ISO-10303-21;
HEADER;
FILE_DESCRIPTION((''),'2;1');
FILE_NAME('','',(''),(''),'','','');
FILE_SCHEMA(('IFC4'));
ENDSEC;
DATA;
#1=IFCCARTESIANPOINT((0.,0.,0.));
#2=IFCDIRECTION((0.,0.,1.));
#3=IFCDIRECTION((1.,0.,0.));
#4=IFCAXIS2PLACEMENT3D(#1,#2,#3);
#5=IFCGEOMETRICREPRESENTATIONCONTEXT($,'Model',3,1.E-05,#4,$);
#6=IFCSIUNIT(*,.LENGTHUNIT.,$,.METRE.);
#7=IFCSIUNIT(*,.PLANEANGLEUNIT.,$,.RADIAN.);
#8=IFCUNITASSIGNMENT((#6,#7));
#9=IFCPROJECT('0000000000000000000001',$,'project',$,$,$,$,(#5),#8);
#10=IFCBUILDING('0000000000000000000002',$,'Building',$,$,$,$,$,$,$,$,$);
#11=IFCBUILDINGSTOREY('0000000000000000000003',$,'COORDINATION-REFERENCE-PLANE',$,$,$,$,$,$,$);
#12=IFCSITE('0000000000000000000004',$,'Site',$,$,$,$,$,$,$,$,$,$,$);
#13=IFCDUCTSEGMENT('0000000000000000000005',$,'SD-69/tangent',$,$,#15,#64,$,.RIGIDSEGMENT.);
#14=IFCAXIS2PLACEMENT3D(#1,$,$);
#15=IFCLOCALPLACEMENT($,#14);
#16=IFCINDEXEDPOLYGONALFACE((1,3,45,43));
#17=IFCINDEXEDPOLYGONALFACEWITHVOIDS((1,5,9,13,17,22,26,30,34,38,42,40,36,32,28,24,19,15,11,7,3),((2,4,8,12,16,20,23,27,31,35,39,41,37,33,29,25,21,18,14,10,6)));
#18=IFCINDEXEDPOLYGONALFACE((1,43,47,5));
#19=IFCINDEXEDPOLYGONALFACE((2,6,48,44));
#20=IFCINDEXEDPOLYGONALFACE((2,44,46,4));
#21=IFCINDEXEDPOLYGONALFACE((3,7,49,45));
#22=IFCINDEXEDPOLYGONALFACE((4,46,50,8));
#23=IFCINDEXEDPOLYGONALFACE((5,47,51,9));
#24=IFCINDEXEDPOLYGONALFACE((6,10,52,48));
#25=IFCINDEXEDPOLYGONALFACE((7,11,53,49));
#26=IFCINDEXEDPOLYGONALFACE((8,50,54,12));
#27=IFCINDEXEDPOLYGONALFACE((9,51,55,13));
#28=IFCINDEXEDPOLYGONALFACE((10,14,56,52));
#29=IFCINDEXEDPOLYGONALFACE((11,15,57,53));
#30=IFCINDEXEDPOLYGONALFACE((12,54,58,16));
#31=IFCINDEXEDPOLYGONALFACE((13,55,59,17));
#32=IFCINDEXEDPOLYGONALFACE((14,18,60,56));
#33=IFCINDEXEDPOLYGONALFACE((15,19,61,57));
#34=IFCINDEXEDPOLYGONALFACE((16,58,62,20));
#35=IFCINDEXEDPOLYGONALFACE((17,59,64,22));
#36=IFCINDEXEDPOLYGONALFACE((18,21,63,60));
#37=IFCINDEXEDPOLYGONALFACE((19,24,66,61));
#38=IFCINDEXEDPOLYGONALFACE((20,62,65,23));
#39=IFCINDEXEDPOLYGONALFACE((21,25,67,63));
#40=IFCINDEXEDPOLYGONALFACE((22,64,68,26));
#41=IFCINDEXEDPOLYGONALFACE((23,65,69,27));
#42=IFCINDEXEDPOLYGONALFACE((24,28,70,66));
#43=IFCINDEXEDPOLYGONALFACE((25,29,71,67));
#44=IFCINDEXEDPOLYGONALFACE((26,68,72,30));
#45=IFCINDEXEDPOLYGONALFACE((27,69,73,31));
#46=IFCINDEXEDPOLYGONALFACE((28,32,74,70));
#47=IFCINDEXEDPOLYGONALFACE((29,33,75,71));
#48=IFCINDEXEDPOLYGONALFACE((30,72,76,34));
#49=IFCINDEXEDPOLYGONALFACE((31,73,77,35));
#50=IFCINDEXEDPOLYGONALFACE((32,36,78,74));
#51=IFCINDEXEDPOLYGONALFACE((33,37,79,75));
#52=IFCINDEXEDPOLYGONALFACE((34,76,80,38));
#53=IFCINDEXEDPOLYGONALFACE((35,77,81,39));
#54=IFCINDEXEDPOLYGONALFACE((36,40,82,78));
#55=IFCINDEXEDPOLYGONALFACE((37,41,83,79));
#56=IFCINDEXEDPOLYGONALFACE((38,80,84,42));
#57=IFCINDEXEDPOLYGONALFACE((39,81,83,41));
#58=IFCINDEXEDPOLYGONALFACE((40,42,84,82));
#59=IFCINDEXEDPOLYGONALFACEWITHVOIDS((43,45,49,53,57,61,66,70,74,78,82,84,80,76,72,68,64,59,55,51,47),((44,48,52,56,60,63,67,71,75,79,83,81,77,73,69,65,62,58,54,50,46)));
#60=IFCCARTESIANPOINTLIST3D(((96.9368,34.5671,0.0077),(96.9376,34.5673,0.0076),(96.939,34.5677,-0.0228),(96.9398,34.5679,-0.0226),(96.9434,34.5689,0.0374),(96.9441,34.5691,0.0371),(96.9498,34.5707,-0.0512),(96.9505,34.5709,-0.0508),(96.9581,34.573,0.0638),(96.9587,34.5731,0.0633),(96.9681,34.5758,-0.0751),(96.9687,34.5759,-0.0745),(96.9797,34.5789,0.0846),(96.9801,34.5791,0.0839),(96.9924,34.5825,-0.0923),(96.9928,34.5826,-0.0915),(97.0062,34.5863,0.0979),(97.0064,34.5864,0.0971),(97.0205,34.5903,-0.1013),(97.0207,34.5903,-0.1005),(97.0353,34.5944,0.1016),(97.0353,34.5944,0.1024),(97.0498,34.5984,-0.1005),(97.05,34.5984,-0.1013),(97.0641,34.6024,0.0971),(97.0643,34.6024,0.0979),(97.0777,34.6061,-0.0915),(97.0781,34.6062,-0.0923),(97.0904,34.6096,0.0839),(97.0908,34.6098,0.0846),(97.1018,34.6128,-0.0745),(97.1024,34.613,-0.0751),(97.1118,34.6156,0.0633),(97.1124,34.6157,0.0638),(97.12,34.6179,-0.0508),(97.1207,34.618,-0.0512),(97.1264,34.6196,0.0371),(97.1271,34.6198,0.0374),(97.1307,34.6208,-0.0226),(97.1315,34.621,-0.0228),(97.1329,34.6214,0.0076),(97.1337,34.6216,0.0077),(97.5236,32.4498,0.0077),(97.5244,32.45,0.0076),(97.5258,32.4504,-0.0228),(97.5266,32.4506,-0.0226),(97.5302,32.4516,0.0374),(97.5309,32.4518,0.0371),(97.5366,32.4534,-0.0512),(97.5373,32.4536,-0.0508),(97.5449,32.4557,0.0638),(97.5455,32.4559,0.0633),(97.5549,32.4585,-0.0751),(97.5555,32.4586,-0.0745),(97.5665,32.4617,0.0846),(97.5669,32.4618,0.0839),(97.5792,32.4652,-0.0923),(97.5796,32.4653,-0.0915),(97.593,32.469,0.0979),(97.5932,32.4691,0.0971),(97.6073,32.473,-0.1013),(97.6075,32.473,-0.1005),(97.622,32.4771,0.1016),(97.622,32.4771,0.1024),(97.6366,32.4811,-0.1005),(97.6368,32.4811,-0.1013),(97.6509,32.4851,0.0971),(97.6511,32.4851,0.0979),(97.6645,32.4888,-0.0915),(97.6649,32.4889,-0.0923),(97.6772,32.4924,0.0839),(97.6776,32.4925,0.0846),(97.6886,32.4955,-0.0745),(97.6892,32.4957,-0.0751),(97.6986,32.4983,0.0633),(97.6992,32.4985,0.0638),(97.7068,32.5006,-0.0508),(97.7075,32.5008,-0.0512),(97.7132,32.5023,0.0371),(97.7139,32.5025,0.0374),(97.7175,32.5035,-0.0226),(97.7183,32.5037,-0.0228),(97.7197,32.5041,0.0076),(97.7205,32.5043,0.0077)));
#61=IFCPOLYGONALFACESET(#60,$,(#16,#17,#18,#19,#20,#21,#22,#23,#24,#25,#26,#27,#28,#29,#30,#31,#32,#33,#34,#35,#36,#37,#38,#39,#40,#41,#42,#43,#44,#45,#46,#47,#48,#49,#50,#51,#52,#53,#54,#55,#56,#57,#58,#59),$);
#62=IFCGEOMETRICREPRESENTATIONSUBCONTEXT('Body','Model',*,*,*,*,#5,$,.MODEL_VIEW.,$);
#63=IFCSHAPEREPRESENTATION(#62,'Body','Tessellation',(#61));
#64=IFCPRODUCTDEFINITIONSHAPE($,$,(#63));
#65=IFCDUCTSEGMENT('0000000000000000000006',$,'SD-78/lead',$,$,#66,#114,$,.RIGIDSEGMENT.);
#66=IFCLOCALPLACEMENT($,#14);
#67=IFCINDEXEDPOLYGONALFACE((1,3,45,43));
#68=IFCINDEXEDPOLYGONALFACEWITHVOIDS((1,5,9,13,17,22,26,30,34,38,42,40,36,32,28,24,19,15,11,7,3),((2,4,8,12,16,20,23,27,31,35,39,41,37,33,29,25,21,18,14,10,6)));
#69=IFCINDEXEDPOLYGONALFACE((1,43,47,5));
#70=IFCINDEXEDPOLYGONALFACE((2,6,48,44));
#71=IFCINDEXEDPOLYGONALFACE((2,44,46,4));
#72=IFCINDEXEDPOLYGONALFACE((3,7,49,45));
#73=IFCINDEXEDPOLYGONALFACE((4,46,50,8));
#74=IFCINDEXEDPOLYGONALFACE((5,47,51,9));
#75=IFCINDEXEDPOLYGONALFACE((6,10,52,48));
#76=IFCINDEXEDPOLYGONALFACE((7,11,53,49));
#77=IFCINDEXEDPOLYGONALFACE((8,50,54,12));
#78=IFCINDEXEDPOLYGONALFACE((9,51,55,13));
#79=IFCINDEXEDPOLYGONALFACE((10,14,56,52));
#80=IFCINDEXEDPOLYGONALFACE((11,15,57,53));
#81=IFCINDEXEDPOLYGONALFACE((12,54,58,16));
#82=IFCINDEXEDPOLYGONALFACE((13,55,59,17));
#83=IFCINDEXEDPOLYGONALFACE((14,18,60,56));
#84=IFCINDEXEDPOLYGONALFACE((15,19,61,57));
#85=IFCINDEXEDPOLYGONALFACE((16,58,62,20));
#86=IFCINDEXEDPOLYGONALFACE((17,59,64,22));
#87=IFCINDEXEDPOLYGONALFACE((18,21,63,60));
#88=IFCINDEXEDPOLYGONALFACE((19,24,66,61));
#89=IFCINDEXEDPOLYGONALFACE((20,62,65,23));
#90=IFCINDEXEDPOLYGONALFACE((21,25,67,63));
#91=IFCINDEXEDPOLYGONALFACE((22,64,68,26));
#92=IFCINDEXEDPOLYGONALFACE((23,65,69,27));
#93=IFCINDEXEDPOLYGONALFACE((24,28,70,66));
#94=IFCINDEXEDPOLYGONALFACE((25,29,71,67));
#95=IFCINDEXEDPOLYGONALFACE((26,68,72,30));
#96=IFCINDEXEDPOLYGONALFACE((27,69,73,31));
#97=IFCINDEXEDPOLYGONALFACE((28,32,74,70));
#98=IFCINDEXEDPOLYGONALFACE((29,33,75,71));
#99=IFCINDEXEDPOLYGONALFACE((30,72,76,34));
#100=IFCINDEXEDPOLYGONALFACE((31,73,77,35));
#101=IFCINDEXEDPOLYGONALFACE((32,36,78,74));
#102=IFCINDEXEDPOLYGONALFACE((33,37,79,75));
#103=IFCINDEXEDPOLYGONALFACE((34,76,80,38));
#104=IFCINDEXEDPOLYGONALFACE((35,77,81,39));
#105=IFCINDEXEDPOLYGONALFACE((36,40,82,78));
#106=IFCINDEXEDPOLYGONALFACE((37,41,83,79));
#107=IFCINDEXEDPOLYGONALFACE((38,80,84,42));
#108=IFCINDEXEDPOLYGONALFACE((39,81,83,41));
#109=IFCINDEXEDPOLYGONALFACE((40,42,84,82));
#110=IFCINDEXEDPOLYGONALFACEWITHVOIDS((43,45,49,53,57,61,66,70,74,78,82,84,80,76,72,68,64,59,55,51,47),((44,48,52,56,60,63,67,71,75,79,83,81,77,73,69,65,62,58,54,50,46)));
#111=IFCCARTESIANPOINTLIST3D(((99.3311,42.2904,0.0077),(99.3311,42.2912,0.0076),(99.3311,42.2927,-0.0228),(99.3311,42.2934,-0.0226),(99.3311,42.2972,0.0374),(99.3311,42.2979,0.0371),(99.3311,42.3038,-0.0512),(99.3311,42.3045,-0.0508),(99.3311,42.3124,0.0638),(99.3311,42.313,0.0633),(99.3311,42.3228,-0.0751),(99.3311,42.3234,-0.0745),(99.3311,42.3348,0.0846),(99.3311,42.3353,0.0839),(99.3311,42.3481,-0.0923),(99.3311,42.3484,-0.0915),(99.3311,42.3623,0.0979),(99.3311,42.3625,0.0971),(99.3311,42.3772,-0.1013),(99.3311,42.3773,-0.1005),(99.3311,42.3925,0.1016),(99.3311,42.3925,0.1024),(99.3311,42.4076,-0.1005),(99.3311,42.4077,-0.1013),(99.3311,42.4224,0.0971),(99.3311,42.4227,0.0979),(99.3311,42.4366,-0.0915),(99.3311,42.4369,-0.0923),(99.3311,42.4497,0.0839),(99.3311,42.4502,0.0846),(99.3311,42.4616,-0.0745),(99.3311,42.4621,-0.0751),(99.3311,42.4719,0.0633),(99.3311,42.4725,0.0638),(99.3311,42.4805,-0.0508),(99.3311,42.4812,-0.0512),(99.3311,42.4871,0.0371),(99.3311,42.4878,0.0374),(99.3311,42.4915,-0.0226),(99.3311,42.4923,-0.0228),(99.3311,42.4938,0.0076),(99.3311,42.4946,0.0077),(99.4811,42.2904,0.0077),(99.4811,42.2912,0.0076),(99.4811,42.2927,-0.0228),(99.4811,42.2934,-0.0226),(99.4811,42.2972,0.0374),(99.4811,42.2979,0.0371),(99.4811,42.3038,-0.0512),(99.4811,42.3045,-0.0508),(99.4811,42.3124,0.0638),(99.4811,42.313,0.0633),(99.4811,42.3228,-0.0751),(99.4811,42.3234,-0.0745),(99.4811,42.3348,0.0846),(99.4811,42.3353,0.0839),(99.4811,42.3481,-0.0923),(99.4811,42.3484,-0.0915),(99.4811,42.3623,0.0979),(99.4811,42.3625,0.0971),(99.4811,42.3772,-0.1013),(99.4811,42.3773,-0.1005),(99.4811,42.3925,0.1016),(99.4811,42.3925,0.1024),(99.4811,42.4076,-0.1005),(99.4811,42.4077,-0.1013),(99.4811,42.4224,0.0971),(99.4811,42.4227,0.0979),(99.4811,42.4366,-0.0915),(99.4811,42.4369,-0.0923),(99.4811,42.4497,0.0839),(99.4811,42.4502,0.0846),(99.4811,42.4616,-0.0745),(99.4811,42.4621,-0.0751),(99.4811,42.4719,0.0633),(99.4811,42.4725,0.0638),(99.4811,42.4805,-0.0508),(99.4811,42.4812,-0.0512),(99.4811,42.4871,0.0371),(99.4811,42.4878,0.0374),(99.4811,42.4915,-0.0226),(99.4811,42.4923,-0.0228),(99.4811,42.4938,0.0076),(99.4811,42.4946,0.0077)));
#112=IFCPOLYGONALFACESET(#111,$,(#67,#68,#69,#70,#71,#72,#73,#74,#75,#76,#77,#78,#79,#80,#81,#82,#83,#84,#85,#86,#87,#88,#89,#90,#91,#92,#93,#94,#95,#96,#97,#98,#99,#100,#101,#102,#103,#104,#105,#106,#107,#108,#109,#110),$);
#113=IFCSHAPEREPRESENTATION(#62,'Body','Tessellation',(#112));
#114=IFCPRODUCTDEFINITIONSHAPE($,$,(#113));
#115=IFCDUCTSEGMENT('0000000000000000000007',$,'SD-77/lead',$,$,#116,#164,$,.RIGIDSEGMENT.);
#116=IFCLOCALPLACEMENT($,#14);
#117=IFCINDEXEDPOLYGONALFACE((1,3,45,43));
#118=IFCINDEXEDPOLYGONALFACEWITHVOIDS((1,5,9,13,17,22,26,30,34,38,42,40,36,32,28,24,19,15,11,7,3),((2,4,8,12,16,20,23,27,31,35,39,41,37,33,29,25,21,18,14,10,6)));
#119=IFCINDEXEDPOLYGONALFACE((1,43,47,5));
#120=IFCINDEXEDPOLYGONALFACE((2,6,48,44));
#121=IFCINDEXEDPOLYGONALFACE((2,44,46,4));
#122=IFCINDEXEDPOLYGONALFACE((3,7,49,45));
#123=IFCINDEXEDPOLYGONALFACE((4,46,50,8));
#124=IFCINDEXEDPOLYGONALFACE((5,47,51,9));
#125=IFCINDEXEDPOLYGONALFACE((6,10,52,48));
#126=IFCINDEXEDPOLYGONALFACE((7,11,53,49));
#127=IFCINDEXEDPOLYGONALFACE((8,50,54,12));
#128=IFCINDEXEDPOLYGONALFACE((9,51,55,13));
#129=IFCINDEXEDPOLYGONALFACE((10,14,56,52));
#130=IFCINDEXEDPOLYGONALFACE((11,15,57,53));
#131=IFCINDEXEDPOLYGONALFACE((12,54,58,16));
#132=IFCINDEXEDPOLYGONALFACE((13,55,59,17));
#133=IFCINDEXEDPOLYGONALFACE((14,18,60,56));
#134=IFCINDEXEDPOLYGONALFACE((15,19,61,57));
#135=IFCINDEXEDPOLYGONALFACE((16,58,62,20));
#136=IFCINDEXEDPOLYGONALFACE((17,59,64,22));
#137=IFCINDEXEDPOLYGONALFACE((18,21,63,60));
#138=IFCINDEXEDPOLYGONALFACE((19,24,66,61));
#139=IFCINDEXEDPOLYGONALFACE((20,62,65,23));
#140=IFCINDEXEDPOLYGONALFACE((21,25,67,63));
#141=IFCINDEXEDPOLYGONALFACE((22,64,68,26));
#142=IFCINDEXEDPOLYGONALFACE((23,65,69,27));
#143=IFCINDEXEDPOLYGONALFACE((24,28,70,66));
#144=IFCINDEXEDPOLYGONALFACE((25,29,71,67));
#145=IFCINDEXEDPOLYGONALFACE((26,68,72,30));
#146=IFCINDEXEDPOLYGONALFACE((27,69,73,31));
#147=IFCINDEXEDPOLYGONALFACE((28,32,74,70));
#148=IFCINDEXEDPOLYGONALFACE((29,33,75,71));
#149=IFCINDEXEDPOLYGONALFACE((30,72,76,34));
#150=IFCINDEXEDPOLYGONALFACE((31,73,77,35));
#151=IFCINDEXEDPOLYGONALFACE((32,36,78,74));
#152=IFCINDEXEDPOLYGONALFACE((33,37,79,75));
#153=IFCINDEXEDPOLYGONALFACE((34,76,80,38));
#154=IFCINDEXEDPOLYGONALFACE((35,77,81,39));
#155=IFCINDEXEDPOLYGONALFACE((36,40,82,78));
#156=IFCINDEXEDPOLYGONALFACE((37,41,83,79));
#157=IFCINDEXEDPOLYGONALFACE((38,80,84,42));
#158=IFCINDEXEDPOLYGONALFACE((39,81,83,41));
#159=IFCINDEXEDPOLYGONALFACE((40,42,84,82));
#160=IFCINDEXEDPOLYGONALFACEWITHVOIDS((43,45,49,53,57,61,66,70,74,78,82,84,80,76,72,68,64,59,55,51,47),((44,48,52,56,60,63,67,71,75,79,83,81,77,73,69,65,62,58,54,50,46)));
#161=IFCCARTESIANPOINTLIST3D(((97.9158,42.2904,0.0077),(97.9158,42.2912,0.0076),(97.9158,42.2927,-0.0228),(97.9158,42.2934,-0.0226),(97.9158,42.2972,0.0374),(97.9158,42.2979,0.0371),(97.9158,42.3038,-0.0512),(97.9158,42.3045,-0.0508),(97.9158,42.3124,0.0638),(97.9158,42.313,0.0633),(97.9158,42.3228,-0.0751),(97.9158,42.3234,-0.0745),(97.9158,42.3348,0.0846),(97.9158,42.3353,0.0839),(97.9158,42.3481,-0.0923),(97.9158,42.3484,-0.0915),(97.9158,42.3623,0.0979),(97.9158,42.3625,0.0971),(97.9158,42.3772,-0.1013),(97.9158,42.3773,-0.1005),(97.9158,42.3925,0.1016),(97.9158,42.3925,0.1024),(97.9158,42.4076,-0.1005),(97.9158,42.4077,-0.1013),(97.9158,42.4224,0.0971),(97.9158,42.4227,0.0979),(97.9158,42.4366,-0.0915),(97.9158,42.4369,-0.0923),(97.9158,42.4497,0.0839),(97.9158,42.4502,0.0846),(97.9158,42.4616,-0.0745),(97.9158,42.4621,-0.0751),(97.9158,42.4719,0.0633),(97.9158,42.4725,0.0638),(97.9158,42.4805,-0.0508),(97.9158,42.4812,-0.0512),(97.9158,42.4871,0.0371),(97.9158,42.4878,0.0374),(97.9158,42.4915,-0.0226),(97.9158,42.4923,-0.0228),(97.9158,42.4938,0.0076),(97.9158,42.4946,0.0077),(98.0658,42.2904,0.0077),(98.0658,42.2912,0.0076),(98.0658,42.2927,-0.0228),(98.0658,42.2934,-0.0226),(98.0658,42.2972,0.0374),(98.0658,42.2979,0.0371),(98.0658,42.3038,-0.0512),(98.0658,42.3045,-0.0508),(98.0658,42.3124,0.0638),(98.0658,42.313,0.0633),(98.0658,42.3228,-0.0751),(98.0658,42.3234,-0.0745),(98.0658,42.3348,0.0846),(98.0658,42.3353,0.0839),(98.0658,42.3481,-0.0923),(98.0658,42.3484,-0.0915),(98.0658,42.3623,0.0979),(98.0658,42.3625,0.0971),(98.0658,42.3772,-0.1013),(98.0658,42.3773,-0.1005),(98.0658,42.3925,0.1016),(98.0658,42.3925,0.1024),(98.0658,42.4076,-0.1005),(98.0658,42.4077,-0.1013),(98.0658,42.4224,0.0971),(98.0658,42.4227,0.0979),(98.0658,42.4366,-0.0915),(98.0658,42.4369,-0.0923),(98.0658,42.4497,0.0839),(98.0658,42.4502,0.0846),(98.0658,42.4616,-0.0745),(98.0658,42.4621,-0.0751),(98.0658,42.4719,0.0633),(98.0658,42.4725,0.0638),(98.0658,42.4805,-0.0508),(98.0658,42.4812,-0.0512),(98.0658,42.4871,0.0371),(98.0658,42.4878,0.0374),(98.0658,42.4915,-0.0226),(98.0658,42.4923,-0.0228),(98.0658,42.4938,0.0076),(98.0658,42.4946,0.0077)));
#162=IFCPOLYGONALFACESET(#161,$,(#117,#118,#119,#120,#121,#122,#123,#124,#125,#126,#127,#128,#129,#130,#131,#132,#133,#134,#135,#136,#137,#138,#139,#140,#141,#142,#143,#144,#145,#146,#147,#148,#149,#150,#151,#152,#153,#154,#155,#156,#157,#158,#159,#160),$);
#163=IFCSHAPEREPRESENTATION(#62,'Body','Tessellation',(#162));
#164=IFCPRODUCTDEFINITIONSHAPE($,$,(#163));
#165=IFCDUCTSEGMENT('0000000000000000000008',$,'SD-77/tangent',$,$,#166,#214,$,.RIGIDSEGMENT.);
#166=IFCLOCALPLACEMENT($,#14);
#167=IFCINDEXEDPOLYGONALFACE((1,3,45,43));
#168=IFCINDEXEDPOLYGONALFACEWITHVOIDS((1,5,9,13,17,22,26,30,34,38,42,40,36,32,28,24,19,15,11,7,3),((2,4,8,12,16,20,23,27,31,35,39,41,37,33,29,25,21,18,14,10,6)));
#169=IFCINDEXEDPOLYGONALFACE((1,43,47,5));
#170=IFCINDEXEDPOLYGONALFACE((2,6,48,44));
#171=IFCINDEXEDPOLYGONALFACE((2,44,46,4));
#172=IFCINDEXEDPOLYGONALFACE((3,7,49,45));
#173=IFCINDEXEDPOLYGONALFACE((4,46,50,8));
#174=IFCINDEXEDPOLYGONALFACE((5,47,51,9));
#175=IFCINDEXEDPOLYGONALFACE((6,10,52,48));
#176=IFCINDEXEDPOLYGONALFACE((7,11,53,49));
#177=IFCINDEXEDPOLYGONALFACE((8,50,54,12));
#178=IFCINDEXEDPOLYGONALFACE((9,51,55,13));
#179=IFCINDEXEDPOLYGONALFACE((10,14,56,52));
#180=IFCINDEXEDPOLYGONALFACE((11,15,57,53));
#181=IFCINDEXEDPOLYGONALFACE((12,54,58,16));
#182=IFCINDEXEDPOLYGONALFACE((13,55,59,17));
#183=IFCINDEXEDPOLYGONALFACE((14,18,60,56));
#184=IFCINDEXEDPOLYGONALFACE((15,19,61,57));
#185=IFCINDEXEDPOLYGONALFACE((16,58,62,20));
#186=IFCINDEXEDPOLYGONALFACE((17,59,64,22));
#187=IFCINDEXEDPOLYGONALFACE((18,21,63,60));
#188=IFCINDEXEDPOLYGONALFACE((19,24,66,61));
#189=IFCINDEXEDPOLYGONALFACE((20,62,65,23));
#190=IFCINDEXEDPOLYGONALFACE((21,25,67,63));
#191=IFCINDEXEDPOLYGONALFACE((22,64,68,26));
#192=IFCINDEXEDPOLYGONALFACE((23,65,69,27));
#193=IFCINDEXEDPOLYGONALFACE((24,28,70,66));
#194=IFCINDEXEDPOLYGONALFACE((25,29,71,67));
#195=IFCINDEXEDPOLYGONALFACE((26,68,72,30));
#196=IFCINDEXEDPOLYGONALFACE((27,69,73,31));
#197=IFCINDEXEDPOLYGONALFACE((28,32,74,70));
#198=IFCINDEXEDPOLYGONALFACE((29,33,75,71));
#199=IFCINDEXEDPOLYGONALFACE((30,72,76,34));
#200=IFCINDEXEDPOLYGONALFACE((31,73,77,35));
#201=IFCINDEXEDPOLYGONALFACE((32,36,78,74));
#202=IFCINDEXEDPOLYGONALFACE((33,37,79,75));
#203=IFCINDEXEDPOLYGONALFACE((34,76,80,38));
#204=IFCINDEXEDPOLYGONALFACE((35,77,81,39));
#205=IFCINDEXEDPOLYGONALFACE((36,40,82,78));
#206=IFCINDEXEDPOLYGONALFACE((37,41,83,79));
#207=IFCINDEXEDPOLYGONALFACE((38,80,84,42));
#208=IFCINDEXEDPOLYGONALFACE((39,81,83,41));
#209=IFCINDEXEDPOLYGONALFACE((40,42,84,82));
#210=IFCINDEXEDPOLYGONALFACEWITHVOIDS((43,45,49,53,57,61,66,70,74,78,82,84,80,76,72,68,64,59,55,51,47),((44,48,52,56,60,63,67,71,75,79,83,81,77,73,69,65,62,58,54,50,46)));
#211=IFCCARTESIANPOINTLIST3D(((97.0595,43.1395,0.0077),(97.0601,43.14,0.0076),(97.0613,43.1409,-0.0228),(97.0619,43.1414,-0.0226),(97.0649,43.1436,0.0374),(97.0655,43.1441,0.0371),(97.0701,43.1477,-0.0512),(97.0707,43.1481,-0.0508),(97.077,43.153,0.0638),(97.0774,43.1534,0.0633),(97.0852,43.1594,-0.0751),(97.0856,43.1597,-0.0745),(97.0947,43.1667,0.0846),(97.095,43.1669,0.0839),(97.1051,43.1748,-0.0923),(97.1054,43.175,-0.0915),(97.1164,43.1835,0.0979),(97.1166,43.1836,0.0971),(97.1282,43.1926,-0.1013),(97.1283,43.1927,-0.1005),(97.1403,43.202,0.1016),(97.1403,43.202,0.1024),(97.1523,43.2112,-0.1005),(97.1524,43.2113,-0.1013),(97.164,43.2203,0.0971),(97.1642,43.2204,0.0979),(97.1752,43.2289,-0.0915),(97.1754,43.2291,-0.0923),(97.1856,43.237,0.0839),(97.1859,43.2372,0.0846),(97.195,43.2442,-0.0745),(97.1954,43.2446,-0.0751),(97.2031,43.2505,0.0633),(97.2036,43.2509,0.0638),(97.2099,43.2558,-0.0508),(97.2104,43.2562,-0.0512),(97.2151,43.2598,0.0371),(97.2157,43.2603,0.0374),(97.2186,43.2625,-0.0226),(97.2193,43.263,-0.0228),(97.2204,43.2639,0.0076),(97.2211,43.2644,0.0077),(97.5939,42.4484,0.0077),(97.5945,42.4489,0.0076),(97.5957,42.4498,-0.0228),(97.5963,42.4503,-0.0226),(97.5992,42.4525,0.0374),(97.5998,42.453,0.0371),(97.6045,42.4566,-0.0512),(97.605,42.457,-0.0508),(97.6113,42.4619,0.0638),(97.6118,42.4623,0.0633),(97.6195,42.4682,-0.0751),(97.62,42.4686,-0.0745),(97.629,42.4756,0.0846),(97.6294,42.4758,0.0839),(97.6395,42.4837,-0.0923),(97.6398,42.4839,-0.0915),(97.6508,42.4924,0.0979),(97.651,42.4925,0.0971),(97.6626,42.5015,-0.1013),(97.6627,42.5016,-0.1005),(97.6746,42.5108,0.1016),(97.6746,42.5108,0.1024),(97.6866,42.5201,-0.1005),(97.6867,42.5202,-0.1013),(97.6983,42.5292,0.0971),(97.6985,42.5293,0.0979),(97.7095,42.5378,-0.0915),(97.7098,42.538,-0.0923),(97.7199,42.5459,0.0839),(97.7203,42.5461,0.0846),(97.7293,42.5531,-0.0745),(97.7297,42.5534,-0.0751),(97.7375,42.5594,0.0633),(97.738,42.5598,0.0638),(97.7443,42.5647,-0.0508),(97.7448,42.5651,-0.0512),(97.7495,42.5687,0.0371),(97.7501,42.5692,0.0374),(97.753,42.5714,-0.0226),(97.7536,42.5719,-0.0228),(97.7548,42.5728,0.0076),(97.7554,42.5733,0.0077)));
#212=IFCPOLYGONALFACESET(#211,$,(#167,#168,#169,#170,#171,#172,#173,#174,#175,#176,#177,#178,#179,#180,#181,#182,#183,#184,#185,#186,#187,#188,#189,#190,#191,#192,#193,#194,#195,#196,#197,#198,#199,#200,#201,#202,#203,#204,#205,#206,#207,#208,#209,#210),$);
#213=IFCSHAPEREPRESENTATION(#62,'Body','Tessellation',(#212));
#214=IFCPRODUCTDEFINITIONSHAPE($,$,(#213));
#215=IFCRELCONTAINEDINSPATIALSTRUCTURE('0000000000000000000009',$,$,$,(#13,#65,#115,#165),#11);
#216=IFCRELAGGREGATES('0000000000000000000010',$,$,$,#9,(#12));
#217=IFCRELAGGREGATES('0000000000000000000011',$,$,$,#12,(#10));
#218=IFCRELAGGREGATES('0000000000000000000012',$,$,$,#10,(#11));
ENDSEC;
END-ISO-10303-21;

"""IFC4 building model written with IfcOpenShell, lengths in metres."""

from ifc_helpers import new_model, si_unit, frame, origin_with_axes, place, context, subcontext, project, spatial, hollow_circle, extrude, element, save


model = new_model("IFC4")

# Units and contexts
model_context_1 = context("Model", 3, precision=1e-05, world=origin_with_axes())
body_context_1 = subcontext(model_context_1, "Body", "Model", "MODEL_VIEW")
ifc_project = project(units=[si_unit("LENGTHUNIT", "METRE"), si_unit("PLANEANGLEUNIT", "RADIAN")], contexts=[model_context_1])

# Site, building, storey
site = spatial("IfcSite", under=ifc_project, Name="Site")
building = spatial("IfcBuilding", under=site, Name="Building")
storey = spatial("IfcBuildingStorey", under=building, Name="COORDINATION-REFERENCE-PLANE")

# Duct segment
duct_segment_1_placement = place(None, frame((97.622, 32.4771, 0.0), z_axis=(-0.267077, 0.963675, 0.0), x_axis=(0.0, 0.0, 1.0)))
element("IfcDuctSegment", 1, at=duct_segment_1_placement, inside=storey, Name="SD-69/tangent", PredefinedType="RIGIDSEGMENT", context=body_context_1, shape_type="SweptSolid", body=[
    extrude(hollow_circle(Radius=0.1024, WallThickness=0.0008), origin_with_axes(), (0.0, 0.0, 1.0), 2.1971),
])

# Duct segments
for number, where, z_axis, x_axis, name in (
    (2, (99.3311, 42.3925, 0.0), (1.0, 0.0, 0.0), (0.0, 0.0, 1.0), "SD-78/lead"),
    (3, (98.0658, 42.3925, 0.0), (-1.0, 0.0, 0.0), (0.0, 0.0, 1.0), "SD-77/lead"),
):
    element("IfcDuctSegment", number, at=place(None, frame(where, z_axis=z_axis, x_axis=x_axis)), inside=storey, Name=name, PredefinedType="RIGIDSEGMENT", context=body_context_1, shape_type="SweptSolid", body=[
        extrude(hollow_circle(Radius=0.1024, WallThickness=0.0008), origin_with_axes(), (0.0, 0.0, 1.0), 0.15),
    ])

# Duct segment
duct_segment_2_placement = place(None, frame((97.6746, 42.5108, 0.0), z_axis=(-0.611676, 0.791108, 0.0), x_axis=(0.0, 0.0, 1.0)))
element("IfcDuctSegment", 4, at=duct_segment_2_placement, inside=storey, Name="SD-77/tangent", PredefinedType="RIGIDSEGMENT", context=body_context_1, shape_type="SweptSolid", body=[
    extrude(hollow_circle(Radius=0.1024, WallThickness=0.0008), origin_with_axes(), (0.0, 0.0, 1.0), 0.8736),
])

save(model, "model.ifc")
